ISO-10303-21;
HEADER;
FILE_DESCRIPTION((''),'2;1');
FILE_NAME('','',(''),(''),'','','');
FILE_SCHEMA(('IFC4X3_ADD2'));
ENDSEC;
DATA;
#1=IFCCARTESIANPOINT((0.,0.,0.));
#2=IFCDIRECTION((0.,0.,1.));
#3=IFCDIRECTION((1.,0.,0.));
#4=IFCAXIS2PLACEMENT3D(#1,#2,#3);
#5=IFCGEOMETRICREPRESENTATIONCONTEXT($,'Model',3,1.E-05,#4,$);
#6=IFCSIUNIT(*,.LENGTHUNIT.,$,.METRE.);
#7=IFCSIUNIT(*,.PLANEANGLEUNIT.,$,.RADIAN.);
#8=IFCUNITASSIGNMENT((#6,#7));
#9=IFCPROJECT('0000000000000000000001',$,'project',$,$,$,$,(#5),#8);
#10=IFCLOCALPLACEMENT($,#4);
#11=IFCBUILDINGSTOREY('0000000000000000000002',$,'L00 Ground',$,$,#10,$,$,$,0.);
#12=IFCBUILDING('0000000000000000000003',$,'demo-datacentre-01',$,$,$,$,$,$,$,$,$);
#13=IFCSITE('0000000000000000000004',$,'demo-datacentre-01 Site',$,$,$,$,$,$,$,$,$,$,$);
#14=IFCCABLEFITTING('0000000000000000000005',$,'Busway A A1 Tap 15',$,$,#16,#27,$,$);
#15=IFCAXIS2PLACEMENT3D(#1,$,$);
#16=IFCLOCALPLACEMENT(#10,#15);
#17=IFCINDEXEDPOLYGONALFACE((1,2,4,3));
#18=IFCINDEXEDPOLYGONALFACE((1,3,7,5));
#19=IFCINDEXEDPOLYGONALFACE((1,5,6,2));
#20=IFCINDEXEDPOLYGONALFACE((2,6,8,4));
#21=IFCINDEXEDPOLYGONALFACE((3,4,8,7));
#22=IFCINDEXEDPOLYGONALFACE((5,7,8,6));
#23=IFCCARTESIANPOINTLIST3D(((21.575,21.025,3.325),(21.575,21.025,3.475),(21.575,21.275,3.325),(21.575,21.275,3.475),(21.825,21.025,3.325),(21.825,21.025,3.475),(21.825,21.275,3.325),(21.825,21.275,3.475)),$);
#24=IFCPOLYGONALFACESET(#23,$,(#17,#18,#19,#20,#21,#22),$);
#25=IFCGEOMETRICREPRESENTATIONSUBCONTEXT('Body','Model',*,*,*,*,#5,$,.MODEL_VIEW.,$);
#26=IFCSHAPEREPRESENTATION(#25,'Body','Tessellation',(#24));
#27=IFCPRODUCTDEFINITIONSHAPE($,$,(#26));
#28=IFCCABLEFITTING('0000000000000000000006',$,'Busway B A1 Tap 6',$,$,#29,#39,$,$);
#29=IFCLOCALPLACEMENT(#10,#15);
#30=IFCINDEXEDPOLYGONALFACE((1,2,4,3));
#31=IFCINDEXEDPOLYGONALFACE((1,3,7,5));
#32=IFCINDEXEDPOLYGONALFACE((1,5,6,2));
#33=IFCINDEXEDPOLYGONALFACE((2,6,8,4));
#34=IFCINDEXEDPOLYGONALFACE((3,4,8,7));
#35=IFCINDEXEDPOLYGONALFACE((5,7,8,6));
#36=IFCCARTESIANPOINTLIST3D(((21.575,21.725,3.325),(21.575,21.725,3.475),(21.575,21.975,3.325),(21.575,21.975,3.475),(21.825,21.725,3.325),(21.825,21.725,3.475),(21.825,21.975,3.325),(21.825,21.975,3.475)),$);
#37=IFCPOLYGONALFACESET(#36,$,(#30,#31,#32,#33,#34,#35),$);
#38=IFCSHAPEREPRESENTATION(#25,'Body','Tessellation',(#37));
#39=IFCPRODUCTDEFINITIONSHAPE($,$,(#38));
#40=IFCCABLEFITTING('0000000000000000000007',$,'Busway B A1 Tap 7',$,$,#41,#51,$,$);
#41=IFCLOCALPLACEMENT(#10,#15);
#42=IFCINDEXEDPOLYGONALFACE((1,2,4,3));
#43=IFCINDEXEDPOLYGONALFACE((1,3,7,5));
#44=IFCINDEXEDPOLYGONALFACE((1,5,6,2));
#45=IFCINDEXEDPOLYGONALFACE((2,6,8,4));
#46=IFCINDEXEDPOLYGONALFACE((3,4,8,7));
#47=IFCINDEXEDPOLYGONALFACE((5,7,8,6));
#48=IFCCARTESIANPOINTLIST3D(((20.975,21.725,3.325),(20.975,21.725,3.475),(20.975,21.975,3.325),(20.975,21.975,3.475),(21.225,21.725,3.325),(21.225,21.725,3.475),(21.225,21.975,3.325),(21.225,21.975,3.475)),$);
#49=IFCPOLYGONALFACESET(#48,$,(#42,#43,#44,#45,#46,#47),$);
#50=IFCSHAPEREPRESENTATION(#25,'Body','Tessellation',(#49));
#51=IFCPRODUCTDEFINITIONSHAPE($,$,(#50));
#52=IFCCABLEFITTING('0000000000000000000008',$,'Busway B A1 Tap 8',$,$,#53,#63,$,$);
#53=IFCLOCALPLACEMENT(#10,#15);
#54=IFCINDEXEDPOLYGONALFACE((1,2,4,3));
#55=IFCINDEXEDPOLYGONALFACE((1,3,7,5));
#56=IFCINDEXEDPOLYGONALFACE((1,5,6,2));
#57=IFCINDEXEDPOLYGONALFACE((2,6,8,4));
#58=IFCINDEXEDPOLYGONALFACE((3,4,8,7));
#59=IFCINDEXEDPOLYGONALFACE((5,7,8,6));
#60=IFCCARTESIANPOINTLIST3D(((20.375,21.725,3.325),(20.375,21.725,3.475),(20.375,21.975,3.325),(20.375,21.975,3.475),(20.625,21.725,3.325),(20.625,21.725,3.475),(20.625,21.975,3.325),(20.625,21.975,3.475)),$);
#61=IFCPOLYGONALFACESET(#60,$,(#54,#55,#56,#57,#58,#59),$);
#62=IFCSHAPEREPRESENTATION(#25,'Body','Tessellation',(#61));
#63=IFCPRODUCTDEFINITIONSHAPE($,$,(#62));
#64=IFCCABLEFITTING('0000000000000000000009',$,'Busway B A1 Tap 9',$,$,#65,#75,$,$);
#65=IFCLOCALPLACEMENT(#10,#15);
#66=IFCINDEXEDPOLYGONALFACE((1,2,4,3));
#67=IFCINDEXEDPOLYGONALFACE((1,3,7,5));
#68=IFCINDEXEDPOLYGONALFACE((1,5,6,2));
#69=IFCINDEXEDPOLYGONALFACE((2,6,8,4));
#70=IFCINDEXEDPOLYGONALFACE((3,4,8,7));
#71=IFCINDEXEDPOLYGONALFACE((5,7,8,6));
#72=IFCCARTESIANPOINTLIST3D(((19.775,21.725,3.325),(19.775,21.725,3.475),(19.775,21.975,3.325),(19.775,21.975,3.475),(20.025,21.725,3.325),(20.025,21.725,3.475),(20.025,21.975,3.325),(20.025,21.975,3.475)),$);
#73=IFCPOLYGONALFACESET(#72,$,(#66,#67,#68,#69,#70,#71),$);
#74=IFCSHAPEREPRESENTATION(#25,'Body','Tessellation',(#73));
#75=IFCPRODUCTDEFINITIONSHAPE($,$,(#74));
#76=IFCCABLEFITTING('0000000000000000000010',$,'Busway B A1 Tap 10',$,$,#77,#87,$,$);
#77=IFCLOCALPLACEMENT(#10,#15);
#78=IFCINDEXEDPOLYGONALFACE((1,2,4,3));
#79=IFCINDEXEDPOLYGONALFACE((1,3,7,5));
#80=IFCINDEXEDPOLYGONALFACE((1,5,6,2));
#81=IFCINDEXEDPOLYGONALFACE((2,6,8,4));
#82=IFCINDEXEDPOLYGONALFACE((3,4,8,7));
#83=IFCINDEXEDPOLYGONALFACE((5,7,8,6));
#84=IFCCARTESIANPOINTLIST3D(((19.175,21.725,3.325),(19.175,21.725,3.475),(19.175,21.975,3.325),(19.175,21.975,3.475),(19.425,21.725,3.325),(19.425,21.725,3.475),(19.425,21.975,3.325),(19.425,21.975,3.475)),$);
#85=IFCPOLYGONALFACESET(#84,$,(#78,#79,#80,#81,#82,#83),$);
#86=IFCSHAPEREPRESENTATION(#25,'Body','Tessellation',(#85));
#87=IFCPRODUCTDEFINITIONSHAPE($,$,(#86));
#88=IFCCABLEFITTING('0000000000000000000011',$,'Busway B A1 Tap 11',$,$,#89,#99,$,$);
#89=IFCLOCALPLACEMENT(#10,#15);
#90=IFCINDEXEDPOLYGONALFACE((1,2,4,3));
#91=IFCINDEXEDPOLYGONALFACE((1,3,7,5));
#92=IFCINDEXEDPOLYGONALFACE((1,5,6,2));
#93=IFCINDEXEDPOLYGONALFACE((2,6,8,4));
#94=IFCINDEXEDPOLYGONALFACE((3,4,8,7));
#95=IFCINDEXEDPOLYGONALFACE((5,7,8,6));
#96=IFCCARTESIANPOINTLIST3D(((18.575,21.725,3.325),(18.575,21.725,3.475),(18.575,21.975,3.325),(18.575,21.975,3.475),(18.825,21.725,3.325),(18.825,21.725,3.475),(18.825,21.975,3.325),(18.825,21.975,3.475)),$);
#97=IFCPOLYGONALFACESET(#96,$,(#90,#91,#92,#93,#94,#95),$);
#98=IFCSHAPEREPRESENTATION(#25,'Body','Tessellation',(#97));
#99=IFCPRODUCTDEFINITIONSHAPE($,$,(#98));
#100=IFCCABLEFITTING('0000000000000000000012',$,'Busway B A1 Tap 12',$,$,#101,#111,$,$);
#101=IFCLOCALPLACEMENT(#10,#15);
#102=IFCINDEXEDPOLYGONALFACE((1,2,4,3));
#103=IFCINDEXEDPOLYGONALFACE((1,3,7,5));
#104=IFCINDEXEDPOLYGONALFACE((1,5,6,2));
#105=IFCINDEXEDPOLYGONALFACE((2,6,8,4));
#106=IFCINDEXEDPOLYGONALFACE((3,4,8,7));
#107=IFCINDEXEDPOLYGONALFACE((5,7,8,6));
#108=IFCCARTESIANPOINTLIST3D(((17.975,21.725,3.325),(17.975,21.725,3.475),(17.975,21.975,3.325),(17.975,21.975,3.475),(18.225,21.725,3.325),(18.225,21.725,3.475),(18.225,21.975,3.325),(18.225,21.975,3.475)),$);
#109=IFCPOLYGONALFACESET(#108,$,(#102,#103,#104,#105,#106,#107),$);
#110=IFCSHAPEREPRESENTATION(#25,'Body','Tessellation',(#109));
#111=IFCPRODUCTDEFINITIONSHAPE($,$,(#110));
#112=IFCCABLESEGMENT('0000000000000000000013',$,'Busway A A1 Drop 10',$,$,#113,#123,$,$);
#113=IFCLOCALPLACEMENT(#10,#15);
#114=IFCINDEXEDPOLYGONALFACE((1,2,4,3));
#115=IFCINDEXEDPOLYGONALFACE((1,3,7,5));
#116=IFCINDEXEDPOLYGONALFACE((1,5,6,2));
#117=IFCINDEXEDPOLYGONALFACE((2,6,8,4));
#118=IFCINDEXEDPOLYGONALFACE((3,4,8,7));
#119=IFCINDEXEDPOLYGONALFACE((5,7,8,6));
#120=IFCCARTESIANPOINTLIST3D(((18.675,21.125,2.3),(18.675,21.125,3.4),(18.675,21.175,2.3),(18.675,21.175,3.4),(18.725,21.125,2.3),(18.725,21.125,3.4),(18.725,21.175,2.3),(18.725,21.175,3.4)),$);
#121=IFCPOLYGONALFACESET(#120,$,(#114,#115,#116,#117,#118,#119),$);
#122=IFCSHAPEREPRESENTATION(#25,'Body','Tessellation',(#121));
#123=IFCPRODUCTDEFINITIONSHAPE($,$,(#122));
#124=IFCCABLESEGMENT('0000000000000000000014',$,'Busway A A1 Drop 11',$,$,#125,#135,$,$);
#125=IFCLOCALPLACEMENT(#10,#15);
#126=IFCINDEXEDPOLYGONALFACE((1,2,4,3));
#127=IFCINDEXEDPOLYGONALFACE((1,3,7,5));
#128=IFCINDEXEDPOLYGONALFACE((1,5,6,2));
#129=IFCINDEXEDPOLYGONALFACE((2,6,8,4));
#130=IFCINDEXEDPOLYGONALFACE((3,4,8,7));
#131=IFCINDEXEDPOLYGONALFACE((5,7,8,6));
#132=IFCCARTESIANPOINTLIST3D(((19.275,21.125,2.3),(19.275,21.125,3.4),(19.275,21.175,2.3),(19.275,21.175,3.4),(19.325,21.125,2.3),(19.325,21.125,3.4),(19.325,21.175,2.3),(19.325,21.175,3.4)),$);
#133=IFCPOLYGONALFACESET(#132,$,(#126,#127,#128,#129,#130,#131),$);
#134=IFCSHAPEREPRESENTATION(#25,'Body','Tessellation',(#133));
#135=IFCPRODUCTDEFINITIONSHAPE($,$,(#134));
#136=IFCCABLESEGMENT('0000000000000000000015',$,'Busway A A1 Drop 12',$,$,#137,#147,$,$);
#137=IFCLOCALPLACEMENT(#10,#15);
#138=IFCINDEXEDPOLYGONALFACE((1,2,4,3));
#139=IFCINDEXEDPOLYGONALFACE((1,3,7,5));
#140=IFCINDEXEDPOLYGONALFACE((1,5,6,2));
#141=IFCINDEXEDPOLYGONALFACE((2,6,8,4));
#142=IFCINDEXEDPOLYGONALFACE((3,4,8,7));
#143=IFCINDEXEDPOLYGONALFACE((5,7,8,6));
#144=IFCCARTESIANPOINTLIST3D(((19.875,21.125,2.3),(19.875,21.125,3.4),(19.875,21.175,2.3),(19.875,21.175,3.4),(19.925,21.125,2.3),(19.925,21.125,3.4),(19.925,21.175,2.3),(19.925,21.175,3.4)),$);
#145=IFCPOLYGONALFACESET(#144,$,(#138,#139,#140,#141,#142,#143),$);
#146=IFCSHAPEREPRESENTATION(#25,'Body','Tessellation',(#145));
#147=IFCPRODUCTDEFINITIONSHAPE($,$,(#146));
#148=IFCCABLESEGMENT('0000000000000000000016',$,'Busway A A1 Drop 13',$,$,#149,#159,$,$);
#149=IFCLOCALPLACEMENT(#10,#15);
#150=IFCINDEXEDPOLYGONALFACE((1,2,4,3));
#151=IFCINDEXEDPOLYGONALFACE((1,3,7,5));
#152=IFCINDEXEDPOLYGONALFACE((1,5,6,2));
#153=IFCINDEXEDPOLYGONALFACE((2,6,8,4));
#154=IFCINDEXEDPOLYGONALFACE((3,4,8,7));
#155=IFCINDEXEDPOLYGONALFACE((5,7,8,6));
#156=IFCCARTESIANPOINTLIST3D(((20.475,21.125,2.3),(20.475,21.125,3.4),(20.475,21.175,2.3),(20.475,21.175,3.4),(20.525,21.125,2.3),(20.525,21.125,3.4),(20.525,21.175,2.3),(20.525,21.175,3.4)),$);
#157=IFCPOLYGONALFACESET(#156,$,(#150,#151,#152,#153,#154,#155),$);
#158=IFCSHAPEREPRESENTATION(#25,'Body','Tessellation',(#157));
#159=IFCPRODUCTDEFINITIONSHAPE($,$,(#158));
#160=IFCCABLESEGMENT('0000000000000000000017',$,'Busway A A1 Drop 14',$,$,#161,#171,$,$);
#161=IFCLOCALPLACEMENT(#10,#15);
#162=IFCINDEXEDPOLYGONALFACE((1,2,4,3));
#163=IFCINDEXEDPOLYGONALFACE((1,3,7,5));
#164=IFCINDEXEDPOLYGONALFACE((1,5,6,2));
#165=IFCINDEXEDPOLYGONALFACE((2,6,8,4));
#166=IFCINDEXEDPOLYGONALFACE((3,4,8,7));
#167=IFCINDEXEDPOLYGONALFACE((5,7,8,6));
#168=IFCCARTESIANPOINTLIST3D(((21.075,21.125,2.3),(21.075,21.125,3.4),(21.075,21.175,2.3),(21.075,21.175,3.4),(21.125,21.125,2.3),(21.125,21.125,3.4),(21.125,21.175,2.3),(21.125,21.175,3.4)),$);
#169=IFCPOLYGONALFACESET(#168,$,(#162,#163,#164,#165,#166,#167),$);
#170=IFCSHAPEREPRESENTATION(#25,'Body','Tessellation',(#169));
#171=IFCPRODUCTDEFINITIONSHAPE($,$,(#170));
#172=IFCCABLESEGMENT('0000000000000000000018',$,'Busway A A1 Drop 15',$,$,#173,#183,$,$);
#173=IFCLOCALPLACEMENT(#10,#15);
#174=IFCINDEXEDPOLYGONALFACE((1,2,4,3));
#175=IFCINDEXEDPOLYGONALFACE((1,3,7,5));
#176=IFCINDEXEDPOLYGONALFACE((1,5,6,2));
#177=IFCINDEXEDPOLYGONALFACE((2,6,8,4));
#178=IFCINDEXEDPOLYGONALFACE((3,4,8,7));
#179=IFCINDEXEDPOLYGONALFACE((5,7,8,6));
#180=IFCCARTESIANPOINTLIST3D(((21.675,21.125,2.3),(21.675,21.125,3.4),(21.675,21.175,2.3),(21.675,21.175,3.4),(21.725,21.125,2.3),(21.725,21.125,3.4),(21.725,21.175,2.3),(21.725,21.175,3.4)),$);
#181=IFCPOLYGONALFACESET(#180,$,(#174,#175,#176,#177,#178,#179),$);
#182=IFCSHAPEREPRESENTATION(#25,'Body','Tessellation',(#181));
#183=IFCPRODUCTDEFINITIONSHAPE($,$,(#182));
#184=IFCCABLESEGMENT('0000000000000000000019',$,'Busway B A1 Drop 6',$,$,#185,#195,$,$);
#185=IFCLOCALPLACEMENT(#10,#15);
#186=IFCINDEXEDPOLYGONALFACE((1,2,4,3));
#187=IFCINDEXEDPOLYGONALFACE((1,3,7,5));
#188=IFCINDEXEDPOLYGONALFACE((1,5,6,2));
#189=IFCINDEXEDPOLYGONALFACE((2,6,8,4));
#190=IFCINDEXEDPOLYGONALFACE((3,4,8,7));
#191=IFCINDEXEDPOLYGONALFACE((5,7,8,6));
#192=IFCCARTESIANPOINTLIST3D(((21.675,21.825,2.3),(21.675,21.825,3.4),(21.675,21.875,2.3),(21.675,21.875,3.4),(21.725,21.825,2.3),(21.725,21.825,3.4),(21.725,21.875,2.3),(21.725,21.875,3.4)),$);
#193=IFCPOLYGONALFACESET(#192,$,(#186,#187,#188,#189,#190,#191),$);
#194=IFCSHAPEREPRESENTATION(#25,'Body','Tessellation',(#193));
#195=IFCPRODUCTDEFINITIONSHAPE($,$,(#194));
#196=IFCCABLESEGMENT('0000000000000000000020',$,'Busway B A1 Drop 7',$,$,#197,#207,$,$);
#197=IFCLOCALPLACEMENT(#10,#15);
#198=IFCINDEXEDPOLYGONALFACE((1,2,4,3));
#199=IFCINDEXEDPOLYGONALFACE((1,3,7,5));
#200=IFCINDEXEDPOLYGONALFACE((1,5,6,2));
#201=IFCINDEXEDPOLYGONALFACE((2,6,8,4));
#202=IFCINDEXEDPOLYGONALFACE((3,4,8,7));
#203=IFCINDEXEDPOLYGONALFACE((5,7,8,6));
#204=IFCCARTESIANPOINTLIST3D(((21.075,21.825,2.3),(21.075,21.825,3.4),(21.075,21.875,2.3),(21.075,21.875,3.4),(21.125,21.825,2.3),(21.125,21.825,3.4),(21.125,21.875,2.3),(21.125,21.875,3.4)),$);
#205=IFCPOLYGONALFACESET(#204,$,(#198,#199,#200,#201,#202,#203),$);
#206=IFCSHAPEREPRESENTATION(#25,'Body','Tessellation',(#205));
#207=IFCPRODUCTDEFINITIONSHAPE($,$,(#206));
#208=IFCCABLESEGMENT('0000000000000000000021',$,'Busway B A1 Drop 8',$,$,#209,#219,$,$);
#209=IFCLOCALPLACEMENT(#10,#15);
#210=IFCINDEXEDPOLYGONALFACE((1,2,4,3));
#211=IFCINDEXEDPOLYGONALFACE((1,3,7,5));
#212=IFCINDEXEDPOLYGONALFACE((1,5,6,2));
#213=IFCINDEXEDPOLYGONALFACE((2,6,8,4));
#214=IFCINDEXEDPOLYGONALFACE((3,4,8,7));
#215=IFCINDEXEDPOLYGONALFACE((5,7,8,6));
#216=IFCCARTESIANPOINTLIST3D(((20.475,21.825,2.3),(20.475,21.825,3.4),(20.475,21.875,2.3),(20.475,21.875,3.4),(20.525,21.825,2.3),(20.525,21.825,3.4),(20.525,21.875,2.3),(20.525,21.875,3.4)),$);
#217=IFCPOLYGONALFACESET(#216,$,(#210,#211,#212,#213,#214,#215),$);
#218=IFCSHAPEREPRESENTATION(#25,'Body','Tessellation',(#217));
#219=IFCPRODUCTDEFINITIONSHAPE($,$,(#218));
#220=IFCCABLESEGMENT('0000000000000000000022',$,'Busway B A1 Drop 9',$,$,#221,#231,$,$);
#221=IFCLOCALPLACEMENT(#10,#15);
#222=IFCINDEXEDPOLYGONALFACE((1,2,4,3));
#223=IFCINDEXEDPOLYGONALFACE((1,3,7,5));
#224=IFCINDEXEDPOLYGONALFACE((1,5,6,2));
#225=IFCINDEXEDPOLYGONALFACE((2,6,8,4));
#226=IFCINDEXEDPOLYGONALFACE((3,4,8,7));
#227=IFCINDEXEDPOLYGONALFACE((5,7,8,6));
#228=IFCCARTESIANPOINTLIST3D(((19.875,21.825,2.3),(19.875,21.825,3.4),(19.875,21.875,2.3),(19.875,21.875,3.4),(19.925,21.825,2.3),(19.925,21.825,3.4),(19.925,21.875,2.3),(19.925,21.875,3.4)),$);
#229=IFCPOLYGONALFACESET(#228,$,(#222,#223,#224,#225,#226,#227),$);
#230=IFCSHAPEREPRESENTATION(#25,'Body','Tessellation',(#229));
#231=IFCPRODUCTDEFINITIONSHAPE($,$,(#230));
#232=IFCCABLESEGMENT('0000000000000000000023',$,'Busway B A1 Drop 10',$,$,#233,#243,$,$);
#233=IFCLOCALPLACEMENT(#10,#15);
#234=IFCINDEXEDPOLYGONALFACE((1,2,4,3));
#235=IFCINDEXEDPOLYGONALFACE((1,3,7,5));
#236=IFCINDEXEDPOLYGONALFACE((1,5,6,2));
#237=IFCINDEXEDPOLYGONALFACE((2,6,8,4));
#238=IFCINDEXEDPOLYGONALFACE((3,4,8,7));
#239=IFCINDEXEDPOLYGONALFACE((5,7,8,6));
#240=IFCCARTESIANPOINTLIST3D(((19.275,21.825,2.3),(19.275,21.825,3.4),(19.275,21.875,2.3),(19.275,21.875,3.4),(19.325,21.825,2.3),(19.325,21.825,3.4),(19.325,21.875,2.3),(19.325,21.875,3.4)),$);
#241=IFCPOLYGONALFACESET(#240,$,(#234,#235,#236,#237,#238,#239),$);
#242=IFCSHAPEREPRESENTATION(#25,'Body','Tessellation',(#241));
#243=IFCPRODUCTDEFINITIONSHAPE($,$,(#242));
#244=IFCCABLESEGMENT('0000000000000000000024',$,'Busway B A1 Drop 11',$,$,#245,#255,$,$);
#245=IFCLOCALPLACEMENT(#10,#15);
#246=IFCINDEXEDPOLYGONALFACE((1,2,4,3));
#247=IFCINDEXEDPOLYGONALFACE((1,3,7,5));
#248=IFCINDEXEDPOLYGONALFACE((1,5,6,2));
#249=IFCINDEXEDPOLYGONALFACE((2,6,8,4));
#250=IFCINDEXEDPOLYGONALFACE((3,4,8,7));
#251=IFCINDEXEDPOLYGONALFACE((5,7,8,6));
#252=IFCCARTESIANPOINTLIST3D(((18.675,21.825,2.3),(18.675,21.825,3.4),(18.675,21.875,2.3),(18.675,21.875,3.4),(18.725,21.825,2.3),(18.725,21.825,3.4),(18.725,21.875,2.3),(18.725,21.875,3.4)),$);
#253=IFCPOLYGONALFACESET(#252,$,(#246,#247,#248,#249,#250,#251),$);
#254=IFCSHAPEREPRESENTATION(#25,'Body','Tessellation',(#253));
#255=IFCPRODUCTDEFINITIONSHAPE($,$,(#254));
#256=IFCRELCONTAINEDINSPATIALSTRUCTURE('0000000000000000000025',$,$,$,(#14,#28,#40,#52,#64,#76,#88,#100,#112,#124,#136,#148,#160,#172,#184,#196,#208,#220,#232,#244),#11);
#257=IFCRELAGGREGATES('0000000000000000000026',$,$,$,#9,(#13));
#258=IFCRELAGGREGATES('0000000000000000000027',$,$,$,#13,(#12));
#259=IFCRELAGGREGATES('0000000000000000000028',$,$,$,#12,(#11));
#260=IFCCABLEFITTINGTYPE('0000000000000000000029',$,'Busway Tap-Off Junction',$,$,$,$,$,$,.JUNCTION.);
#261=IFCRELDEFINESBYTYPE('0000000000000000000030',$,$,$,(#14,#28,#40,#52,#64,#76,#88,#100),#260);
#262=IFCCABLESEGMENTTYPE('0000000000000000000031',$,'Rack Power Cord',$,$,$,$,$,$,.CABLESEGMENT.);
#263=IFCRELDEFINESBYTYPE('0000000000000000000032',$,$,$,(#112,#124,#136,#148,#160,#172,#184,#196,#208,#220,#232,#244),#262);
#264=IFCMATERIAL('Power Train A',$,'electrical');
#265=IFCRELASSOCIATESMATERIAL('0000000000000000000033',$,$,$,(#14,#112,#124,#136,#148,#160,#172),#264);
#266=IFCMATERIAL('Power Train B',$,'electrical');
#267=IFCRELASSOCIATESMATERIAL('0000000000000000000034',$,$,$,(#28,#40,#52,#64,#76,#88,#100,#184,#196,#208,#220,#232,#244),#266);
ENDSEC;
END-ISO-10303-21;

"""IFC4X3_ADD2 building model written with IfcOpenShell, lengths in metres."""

from ifc_helpers import new_model, si_unit, frame, origin_with_axes, place, context, subcontext, project, spatial, rectangle, extrude, material, type_object, element, save


model = new_model("IFC4X3_ADD2")

# Units and contexts
model_context = context("Model", 3, precision=1e-05, world=origin_with_axes())
body_context = subcontext(model_context, "Body", "Model", "MODEL_VIEW")
ifc_project = project(units=[si_unit("LENGTHUNIT", "METRE"), si_unit("PLANEANGLEUNIT", "RADIAN")], contexts=[model_context])

# Site, building, storey
site = spatial("IfcSite", under=ifc_project, Name="demo-datacentre-01 Site")
building = spatial("IfcBuilding", under=site, Name="demo-datacentre-01")
storey_placement = place(None, origin_with_axes())
storey = spatial("IfcBuildingStorey", under=building, at=storey_placement, Name="L00 Ground", Elevation=0.0)

# Shared definitions
ifc_material_1 = material(Name="Power Train A", Category="electrical")
ifc_material_2 = material(Name="Power Train B", Category="electrical")

# Cable fittings
cable_fitting_type = type_object("IfcCableFittingType", Name="Busway Tap-Off Junction", PredefinedType="JUNCTION")
for number, where, z_axis, x_axis, name in (
    (1, (21.7, 21.15, 3.325), (0.0, 0.0, 1.0), (1.0, 0.0, 0.0), "Busway A A1 Tap 15"),
):
    element("IfcCableFitting", number, at=place(storey_placement, frame(where, z_axis=z_axis, x_axis=x_axis)), inside=storey, type_object=cable_fitting_type, material=ifc_material_1, Name=name, context=body_context, shape_type="SweptSolid", body=[
        extrude(rectangle(XDim=0.25, YDim=0.25), origin_with_axes(), (0.0, 0.0, 1.0), 0.15),
    ])
for number, where, z_axis, x_axis, name in (
    (2, (21.7, 21.85, 3.325), (0.0, 0.0, 1.0), (1.0, 0.0, 0.0), "Busway B A1 Tap 6"),
    (3, (21.1, 21.85, 3.325), (0.0, 0.0, 1.0), (1.0, 0.0, 0.0), "Busway B A1 Tap 7"),
    (4, (20.5, 21.85, 3.325), (0.0, 0.0, 1.0), (1.0, 0.0, 0.0), "Busway B A1 Tap 8"),
    (5, (19.9, 21.85, 3.325), (0.0, 0.0, 1.0), (1.0, 0.0, 0.0), "Busway B A1 Tap 9"),
    (6, (19.3, 21.85, 3.325), (0.0, 0.0, 1.0), (1.0, 0.0, 0.0), "Busway B A1 Tap 10"),
    (7, (18.7, 21.85, 3.325), (0.0, 0.0, 1.0), (1.0, 0.0, 0.0), "Busway B A1 Tap 11"),
    (8, (18.1, 21.85, 3.325), (0.0, 0.0, 1.0), (1.0, 0.0, 0.0), "Busway B A1 Tap 12"),
):
    element("IfcCableFitting", number, at=place(storey_placement, frame(where, z_axis=z_axis, x_axis=x_axis)), inside=storey, type_object=cable_fitting_type, material=ifc_material_2, Name=name, context=body_context, shape_type="SweptSolid", body=[
        extrude(rectangle(XDim=0.25, YDim=0.25), origin_with_axes(), (0.0, 0.0, 1.0), 0.15),
    ])

# Cable segments
cable_segment_type_1 = type_object("IfcCableSegmentType", Name="Rack Power Cord", PredefinedType="CABLESEGMENT")
for number, where, z_axis, x_axis, name in (
    (9, (18.7, 21.15, 3.4), (0.0, 0.0, -1.0), (1.0, 0.0, 0.0), "Busway A A1 Drop 10"),
    (10, (19.3, 21.15, 3.4), (0.0, 0.0, -1.0), (1.0, 0.0, 0.0), "Busway A A1 Drop 11"),
    (11, (19.9, 21.15, 3.4), (0.0, 0.0, -1.0), (1.0, 0.0, 0.0), "Busway A A1 Drop 12"),
    (12, (20.5, 21.15, 3.4), (0.0, 0.0, -1.0), (1.0, 0.0, 0.0), "Busway A A1 Drop 13"),
    (13, (21.1, 21.15, 3.4), (0.0, 0.0, -1.0), (1.0, 0.0, 0.0), "Busway A A1 Drop 14"),
    (14, (21.7, 21.15, 3.4), (0.0, 0.0, -1.0), (1.0, 0.0, 0.0), "Busway A A1 Drop 15"),
):
    element("IfcCableSegment", number, at=place(storey_placement, frame(where, z_axis=z_axis, x_axis=x_axis)), inside=storey, type_object=cable_segment_type_1, material=ifc_material_1, Name=name, context=body_context, shape_type="SweptSolid", body=[
        extrude(rectangle(XDim=0.05, YDim=0.05), origin_with_axes(), (0.0, 0.0, 1.0), 1.1),
    ])
for number, where, z_axis, x_axis, name in (
    (15, (21.7, 21.85, 3.4), (0.0, 0.0, -1.0), (1.0, 0.0, 0.0), "Busway B A1 Drop 6"),
    (16, (21.1, 21.85, 3.4), (0.0, 0.0, -1.0), (1.0, 0.0, 0.0), "Busway B A1 Drop 7"),
    (17, (20.5, 21.85, 3.4), (0.0, 0.0, -1.0), (1.0, 0.0, 0.0), "Busway B A1 Drop 8"),
    (18, (19.9, 21.85, 3.4), (0.0, 0.0, -1.0), (1.0, 0.0, 0.0), "Busway B A1 Drop 9"),
    (19, (19.3, 21.85, 3.4), (0.0, 0.0, -1.0), (1.0, 0.0, 0.0), "Busway B A1 Drop 10"),
    (20, (18.7, 21.85, 3.4), (0.0, 0.0, -1.0), (1.0, 0.0, 0.0), "Busway B A1 Drop 11"),
):
    element("IfcCableSegment", number, at=place(storey_placement, frame(where, z_axis=z_axis, x_axis=x_axis)), inside=storey, type_object=cable_segment_type_1, material=ifc_material_2, Name=name, context=body_context, shape_type="SweptSolid", body=[
        extrude(rectangle(XDim=0.05, YDim=0.05), origin_with_axes(), (0.0, 0.0, 1.0), 1.1),
    ])

save(model, "model.ifc")
